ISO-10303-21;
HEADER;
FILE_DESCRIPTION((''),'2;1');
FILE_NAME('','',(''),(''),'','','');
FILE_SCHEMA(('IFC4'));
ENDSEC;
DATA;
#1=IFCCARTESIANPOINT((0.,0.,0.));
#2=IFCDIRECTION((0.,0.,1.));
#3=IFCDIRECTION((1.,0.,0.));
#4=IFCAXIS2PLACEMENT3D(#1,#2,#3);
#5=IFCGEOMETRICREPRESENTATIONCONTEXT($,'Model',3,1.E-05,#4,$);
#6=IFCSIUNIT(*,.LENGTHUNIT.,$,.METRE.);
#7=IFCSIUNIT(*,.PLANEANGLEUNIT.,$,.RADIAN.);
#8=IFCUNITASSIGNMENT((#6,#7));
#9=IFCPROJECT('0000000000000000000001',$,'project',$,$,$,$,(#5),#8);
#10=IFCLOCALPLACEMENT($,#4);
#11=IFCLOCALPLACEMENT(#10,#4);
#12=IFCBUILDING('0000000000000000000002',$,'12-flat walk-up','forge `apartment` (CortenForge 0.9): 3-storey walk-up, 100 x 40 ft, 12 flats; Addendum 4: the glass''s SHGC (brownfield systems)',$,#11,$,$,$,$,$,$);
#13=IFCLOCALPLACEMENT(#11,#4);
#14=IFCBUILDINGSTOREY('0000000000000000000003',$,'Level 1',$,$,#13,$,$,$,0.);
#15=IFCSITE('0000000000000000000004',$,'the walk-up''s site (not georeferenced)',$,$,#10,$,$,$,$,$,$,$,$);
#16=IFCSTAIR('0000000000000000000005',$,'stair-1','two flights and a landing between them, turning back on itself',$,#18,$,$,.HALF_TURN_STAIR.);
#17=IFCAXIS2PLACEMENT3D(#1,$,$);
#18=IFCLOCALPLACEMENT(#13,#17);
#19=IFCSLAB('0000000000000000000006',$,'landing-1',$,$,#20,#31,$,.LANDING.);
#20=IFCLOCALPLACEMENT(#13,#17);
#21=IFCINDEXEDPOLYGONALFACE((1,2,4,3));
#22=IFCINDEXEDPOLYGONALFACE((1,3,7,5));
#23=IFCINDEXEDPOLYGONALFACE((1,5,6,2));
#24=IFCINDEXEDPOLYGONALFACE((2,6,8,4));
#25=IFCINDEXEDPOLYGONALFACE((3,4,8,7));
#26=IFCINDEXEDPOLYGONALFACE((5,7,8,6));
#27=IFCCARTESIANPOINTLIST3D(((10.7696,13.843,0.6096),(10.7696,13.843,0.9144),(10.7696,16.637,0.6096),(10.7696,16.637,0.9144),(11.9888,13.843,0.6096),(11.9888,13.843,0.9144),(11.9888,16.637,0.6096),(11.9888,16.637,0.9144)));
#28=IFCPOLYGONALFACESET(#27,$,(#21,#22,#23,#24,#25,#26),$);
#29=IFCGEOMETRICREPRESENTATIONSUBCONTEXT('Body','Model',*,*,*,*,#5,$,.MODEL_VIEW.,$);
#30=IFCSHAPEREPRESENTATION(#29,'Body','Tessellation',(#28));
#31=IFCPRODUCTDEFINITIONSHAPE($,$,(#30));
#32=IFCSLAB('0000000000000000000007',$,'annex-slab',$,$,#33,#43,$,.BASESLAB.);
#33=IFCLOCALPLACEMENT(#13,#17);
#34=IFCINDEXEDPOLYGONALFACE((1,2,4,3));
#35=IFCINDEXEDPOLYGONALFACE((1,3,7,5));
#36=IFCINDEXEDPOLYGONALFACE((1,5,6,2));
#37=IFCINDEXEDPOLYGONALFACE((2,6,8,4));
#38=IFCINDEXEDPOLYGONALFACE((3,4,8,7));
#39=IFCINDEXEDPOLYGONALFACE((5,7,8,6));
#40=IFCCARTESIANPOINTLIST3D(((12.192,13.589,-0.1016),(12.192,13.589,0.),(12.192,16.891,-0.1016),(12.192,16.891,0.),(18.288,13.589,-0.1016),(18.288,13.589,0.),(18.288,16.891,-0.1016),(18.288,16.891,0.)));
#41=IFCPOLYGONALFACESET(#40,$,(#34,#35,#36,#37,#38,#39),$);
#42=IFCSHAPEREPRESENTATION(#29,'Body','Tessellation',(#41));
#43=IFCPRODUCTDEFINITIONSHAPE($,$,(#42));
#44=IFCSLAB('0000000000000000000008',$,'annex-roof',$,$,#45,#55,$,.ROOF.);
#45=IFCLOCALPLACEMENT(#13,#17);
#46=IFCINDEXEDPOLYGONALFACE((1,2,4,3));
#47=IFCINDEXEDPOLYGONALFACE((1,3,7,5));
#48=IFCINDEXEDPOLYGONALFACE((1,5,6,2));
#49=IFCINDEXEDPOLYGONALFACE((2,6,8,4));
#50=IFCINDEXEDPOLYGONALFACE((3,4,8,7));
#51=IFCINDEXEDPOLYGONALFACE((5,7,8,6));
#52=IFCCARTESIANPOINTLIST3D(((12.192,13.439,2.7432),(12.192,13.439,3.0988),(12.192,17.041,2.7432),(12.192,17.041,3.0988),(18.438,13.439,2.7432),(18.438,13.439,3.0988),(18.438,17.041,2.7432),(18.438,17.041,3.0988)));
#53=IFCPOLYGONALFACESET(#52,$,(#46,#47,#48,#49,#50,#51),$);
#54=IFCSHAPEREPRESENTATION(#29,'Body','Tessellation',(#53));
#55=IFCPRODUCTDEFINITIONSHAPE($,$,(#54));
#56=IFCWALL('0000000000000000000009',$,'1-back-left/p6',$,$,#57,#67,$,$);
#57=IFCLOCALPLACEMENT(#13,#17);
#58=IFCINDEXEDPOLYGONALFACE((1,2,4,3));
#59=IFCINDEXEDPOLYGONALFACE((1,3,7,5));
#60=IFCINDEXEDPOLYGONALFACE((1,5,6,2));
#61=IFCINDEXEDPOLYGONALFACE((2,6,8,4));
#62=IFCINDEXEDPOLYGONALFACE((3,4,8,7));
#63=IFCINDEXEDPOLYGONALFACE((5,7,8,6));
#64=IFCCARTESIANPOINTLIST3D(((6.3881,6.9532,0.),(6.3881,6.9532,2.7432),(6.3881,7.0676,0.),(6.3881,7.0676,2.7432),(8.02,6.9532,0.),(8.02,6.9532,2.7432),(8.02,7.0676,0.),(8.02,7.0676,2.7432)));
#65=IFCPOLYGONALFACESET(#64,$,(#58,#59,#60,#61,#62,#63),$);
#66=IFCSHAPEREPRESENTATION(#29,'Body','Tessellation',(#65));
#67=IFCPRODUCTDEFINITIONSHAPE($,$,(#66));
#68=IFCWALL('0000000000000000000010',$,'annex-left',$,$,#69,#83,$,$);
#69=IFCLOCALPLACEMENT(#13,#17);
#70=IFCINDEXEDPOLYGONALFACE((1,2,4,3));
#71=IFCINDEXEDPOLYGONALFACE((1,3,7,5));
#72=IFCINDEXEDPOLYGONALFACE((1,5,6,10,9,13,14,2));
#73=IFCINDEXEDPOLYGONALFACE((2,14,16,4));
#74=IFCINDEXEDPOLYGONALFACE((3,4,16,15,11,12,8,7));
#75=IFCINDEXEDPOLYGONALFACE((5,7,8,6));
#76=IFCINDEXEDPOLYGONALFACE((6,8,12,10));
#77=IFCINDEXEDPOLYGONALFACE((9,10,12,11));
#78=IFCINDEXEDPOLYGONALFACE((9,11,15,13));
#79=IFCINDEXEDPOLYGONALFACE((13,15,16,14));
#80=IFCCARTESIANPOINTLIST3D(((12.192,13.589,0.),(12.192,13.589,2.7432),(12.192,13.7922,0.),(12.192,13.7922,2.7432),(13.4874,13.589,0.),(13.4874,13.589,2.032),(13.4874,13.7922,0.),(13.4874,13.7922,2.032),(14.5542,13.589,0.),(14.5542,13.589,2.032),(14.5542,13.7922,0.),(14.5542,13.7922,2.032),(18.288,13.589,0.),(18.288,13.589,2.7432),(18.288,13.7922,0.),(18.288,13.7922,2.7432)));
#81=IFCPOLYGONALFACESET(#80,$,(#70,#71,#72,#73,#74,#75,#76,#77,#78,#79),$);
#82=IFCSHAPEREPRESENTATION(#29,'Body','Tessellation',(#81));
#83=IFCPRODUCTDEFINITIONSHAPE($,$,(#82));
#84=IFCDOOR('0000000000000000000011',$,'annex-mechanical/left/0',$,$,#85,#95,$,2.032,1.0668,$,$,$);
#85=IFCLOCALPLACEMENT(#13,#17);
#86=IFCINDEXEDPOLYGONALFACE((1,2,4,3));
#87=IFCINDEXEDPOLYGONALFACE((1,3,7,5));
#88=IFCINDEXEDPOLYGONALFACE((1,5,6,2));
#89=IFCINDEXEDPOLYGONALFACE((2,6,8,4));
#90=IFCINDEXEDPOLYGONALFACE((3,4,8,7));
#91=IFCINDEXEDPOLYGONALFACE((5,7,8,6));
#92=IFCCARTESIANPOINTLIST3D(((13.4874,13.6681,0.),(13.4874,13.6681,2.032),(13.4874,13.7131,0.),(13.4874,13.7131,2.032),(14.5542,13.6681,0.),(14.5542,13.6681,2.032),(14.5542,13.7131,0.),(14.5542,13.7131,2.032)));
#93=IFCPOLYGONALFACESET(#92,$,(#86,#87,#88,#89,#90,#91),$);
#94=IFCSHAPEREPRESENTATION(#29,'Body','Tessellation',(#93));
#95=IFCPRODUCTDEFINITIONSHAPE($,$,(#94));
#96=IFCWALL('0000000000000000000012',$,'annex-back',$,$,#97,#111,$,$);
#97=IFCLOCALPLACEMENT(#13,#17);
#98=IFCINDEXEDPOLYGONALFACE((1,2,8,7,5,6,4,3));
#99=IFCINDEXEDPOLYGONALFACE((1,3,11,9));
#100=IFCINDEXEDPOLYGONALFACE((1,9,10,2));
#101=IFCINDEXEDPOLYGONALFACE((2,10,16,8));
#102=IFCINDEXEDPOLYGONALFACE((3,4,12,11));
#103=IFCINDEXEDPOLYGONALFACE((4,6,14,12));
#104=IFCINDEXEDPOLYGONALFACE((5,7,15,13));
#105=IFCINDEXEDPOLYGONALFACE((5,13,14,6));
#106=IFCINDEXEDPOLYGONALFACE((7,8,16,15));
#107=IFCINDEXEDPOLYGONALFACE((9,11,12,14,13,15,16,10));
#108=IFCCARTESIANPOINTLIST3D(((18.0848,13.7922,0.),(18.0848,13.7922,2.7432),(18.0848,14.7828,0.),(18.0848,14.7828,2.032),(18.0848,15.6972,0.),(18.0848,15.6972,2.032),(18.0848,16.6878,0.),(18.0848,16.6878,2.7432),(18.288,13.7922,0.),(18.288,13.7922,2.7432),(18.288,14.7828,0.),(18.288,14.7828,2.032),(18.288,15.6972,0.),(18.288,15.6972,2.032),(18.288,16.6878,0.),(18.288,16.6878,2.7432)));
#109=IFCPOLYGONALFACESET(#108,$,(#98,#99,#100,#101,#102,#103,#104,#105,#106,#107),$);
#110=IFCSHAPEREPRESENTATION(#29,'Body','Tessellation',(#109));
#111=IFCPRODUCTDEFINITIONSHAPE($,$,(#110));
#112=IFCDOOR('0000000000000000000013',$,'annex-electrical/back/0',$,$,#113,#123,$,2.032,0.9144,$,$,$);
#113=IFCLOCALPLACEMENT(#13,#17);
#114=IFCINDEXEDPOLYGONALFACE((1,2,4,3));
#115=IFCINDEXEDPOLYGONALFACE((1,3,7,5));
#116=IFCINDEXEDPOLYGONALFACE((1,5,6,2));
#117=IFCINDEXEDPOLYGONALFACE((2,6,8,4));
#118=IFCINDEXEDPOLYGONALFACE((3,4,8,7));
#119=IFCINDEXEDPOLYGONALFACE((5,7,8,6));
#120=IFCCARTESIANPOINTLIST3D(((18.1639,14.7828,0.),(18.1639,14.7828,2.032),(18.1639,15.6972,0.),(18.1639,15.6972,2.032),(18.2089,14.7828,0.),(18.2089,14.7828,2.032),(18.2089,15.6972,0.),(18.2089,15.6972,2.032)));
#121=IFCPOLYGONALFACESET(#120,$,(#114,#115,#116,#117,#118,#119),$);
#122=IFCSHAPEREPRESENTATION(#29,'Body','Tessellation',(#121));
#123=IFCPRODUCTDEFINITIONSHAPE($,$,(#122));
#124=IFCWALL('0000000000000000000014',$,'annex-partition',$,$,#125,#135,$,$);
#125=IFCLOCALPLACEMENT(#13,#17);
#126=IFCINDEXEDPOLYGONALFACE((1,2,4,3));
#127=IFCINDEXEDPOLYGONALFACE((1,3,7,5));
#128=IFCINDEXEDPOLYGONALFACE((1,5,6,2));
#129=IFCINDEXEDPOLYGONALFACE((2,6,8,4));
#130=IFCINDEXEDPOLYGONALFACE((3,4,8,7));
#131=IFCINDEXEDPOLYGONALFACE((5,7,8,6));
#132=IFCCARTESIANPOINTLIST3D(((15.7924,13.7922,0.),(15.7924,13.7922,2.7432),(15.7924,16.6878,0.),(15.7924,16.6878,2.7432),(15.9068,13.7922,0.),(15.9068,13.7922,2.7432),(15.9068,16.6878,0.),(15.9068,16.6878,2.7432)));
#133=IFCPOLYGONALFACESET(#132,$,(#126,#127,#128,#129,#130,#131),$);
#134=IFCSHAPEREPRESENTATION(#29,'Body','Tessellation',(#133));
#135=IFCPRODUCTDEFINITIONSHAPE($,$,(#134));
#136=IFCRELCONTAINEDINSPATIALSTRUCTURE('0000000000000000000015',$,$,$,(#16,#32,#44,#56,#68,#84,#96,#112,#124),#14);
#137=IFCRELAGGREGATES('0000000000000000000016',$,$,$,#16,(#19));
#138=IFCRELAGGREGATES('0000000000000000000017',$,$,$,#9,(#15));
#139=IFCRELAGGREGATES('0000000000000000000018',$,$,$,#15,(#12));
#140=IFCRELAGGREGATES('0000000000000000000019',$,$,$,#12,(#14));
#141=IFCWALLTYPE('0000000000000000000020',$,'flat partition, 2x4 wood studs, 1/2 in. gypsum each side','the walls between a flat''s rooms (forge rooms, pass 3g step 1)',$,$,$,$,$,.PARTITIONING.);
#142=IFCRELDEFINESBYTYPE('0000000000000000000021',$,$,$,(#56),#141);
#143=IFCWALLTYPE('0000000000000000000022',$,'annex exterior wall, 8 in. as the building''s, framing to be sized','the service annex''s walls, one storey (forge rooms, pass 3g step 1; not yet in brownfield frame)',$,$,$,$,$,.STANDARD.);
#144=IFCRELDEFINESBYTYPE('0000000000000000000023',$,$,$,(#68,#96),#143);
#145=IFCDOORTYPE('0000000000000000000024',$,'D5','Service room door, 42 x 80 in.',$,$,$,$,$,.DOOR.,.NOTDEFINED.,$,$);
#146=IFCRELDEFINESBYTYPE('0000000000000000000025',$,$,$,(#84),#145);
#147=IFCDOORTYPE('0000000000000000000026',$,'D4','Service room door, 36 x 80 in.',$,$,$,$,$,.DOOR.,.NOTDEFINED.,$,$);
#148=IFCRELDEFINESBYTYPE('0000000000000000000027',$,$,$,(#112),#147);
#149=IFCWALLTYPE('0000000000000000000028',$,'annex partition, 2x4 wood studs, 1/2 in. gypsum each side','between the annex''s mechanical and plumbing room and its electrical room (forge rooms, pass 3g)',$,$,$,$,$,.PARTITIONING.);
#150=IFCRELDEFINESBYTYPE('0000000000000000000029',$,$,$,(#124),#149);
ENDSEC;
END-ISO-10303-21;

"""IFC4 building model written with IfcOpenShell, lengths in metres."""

from ifc_helpers import new_model, si_unit, frame, frame_2d, origin, origin_with_axes, place, context, subcontext, project, spatial, rectangle, extrude, type_object, element, fill, aggregate, save


model = new_model("IFC4")

# Units and contexts
model_context = context("Model", 3, precision=1e-05, world=origin_with_axes())
body_context = subcontext(model_context, "Body", "Model", "MODEL_VIEW")
ifc_project = project(units=[si_unit("LENGTHUNIT", "METRE"), si_unit("PLANEANGLEUNIT", "RADIAN")], contexts=[model_context])

# Site, building, storey
site_placement = place(None, origin_with_axes())
site = spatial("IfcSite", under=ifc_project, at=site_placement, Name="the walk-up's site (not georeferenced)")
building_placement = place(site_placement, origin_with_axes())
building = spatial("IfcBuilding", under=site, at=building_placement, Name="12-flat walk-up", Description="forge `apartment` (CortenForge 0.9): 3-storey walk-up, 100 x 40 ft, 12 flats; Addendum 4: the glass's SHGC (brownfield systems)")
storey_placement = place(building_placement, origin_with_axes())
storey = spatial("IfcBuildingStorey", under=building, at=storey_placement, Name="Level 1", Elevation=0.0)

# Stair, slab
stair_placement = place(storey_placement, origin_with_axes())
stair = element("IfcStair", 1, at=stair_placement, inside=storey, Name="stair-1", Description="two flights and a landing between them, turning back on itself", PredefinedType="HALF_TURN_STAIR")
slab_1_placement = place(stair_placement, frame((10.7696, 13.843, 0.6096), z_axis=(0.0, 0.0, 1.0), x_axis=(1.0, 0.0, 0.0)))
slab_1 = element("IfcSlab", 2, at=slab_1_placement, Name="landing-1", PredefinedType="LANDING", context=body_context, shape_type="SweptSolid", body=[
    extrude(rectangle(XDim=1.2192, YDim=2.794, at=frame_2d((0.6096, 1.397))), origin(), (0.0, 0.0, 1.0), 0.3048),
])
aggregate(stair, [slab_1])

# Slabs
slab_2_placement = place(storey_placement, frame((12.192, 13.589, -0.1016), z_axis=(0.0, 0.0, 1.0), x_axis=(1.0, 0.0, 0.0)))
element("IfcSlab", 3, at=slab_2_placement, inside=storey, Name="annex-slab", PredefinedType="BASESLAB", context=body_context, shape_type="SweptSolid", body=[
    extrude(rectangle(XDim=6.096, YDim=3.302, at=frame_2d((3.048, 1.651))), origin(), (0.0, 0.0, 1.0), 0.1016),
])
slab_3_placement = place(storey_placement, frame((12.192, 13.439, 2.7432), z_axis=(0.0, 0.0, 1.0), x_axis=(1.0, 0.0, 0.0)))
element("IfcSlab", 4, at=slab_3_placement, inside=storey, Name="annex-roof", PredefinedType="ROOF", context=body_context, shape_type="SweptSolid", body=[
    extrude(rectangle(XDim=6.246, YDim=3.602, at=frame_2d((3.123, 1.801))), origin(), (0.0, 0.0, 1.0), 0.3556),
])

# Wall
wall_type_1 = type_object("IfcWallType", Name="flat partition, 2x4 wood studs, 1/2 in. gypsum each side", Description="the walls between a flat's rooms (forge rooms, pass 3g step 1)", PredefinedType="PARTITIONING")
wall_1_placement = place(storey_placement, frame((6.3881, 6.9532, 0.0), z_axis=(0.0, 0.0, 1.0), x_axis=(1.0, 0.0, 0.0)))
element("IfcWall", 5, at=wall_1_placement, inside=storey, type_object=wall_type_1, Name="1-back-left/p6", context=body_context, shape_type="SweptSolid", body=[
    extrude(rectangle(XDim=1.6319, YDim=0.1143, at=frame_2d((0.816, 0.0572))), origin(), (0.0, 0.0, 1.0), 2.7432),
])

# Walls, openings, doors
wall_type_2 = type_object("IfcWallType", Name="annex exterior wall, 8 in. as the building's, framing to be sized", Description="the service annex's walls, one storey (forge rooms, pass 3g step 1; not yet in brownfield frame)", PredefinedType="STANDARD")
wall_2_placement = place(storey_placement, frame((12.192, 13.589, 0.0), z_axis=(0.0, 0.0, 1.0), x_axis=(1.0, 0.0, 0.0)))
wall_2 = element("IfcWall", 6, at=wall_2_placement, inside=storey, type_object=wall_type_2, Name="annex-left", context=body_context, shape_type="SweptSolid", body=[
    extrude(rectangle(XDim=6.096, YDim=0.2032, at=frame_2d((3.048, 0.1016))), origin(), (0.0, 0.0, 1.0), 2.7432),
])
opening_1_placement = place(wall_2_placement, frame((1.2954, 0.0, 0.0), z_axis=(0.0, 0.0, 1.0), x_axis=(1.0, 0.0, 0.0)))
opening_1 = element("IfcOpeningElement", 7, at=opening_1_placement, cuts=wall_2, PredefinedType="OPENING", context=body_context, shape_type="SweptSolid", body=[
    extrude(rectangle(XDim=1.0668, YDim=0.2032, at=frame_2d((0.5334, 0.1016))), origin(), (0.0, 0.0, 1.0), 2.032),
])
door_type_1 = type_object("IfcDoorType", Name="D5", Description="Service room door, 42 x 80 in.", OperationType="NOTDEFINED", PredefinedType="DOOR")
door_1_placement = place(opening_1_placement, frame((0.0, 0.0791, 0.0), z_axis=(0.0, 0.0, 1.0), x_axis=(1.0, 0.0, 0.0)))
door_1 = element("IfcDoor", 8, at=door_1_placement, inside=storey, type_object=door_type_1, Name="annex-mechanical/left/0", OverallHeight=2.032, OverallWidth=1.0668, context=body_context, shape_type="SweptSolid", body=[
    extrude(rectangle(XDim=1.0668, YDim=0.045, at=frame_2d((0.5334, 0.0225))), origin(), (0.0, 0.0, 1.0), 2.032),
])
fill(opening_1, door_1)
wall_3_placement = place(storey_placement, frame((18.0848, 13.7922, 0.0), z_axis=(0.0, 0.0, 1.0), x_axis=(1.0, 0.0, 0.0)))
wall_3 = element("IfcWall", 9, at=wall_3_placement, inside=storey, type_object=wall_type_2, Name="annex-back", context=body_context, shape_type="SweptSolid", body=[
    extrude(rectangle(XDim=0.2032, YDim=2.8956, at=frame_2d((0.1016, 1.4478))), origin(), (0.0, 0.0, 1.0), 2.7432),
])
opening_2_placement = place(wall_3_placement, frame((0.2032, 0.9906, 0.0), z_axis=(0.0, 0.0, 1.0), x_axis=(0.0, 1.0, 0.0)))
opening_2 = element("IfcOpeningElement", 10, at=opening_2_placement, cuts=wall_3, PredefinedType="OPENING", context=body_context, shape_type="SweptSolid", body=[
    extrude(rectangle(XDim=0.9144, YDim=0.2032, at=frame_2d((0.4572, 0.1016))), origin(), (0.0, 0.0, 1.0), 2.032),
])
door_type_2 = type_object("IfcDoorType", Name="D4", Description="Service room door, 36 x 80 in.", OperationType="NOTDEFINED", PredefinedType="DOOR")
door_2_placement = place(opening_2_placement, frame((0.0, 0.0791, 0.0), z_axis=(0.0, 0.0, 1.0), x_axis=(1.0, 0.0, 0.0)))
door_2 = element("IfcDoor", 11, at=door_2_placement, inside=storey, type_object=door_type_2, Name="annex-electrical/back/0", OverallHeight=2.032, OverallWidth=0.9144, context=body_context, shape_type="SweptSolid", body=[
    extrude(rectangle(XDim=0.9144, YDim=0.045, at=frame_2d((0.4572, 0.0225))), origin(), (0.0, 0.0, 1.0), 2.032),
])
fill(opening_2, door_2)

# Wall
wall_type_3 = type_object("IfcWallType", Name="annex partition, 2x4 wood studs, 1/2 in. gypsum each side", Description="between the annex's mechanical and plumbing room and its electrical room (forge rooms, pass 3g)", PredefinedType="PARTITIONING")
wall_4_placement = place(storey_placement, frame((15.7925, 13.7922, 0.0), z_axis=(0.0, 0.0, 1.0), x_axis=(1.0, 0.0, 0.0)))
element("IfcWall", 12, at=wall_4_placement, inside=storey, type_object=wall_type_3, Name="annex-partition", context=body_context, shape_type="SweptSolid", body=[
    extrude(rectangle(XDim=0.1143, YDim=2.8956, at=frame_2d((0.0572, 1.4478))), origin(), (0.0, 0.0, 1.0), 2.7432),
])

save(model, "model.ifc")
